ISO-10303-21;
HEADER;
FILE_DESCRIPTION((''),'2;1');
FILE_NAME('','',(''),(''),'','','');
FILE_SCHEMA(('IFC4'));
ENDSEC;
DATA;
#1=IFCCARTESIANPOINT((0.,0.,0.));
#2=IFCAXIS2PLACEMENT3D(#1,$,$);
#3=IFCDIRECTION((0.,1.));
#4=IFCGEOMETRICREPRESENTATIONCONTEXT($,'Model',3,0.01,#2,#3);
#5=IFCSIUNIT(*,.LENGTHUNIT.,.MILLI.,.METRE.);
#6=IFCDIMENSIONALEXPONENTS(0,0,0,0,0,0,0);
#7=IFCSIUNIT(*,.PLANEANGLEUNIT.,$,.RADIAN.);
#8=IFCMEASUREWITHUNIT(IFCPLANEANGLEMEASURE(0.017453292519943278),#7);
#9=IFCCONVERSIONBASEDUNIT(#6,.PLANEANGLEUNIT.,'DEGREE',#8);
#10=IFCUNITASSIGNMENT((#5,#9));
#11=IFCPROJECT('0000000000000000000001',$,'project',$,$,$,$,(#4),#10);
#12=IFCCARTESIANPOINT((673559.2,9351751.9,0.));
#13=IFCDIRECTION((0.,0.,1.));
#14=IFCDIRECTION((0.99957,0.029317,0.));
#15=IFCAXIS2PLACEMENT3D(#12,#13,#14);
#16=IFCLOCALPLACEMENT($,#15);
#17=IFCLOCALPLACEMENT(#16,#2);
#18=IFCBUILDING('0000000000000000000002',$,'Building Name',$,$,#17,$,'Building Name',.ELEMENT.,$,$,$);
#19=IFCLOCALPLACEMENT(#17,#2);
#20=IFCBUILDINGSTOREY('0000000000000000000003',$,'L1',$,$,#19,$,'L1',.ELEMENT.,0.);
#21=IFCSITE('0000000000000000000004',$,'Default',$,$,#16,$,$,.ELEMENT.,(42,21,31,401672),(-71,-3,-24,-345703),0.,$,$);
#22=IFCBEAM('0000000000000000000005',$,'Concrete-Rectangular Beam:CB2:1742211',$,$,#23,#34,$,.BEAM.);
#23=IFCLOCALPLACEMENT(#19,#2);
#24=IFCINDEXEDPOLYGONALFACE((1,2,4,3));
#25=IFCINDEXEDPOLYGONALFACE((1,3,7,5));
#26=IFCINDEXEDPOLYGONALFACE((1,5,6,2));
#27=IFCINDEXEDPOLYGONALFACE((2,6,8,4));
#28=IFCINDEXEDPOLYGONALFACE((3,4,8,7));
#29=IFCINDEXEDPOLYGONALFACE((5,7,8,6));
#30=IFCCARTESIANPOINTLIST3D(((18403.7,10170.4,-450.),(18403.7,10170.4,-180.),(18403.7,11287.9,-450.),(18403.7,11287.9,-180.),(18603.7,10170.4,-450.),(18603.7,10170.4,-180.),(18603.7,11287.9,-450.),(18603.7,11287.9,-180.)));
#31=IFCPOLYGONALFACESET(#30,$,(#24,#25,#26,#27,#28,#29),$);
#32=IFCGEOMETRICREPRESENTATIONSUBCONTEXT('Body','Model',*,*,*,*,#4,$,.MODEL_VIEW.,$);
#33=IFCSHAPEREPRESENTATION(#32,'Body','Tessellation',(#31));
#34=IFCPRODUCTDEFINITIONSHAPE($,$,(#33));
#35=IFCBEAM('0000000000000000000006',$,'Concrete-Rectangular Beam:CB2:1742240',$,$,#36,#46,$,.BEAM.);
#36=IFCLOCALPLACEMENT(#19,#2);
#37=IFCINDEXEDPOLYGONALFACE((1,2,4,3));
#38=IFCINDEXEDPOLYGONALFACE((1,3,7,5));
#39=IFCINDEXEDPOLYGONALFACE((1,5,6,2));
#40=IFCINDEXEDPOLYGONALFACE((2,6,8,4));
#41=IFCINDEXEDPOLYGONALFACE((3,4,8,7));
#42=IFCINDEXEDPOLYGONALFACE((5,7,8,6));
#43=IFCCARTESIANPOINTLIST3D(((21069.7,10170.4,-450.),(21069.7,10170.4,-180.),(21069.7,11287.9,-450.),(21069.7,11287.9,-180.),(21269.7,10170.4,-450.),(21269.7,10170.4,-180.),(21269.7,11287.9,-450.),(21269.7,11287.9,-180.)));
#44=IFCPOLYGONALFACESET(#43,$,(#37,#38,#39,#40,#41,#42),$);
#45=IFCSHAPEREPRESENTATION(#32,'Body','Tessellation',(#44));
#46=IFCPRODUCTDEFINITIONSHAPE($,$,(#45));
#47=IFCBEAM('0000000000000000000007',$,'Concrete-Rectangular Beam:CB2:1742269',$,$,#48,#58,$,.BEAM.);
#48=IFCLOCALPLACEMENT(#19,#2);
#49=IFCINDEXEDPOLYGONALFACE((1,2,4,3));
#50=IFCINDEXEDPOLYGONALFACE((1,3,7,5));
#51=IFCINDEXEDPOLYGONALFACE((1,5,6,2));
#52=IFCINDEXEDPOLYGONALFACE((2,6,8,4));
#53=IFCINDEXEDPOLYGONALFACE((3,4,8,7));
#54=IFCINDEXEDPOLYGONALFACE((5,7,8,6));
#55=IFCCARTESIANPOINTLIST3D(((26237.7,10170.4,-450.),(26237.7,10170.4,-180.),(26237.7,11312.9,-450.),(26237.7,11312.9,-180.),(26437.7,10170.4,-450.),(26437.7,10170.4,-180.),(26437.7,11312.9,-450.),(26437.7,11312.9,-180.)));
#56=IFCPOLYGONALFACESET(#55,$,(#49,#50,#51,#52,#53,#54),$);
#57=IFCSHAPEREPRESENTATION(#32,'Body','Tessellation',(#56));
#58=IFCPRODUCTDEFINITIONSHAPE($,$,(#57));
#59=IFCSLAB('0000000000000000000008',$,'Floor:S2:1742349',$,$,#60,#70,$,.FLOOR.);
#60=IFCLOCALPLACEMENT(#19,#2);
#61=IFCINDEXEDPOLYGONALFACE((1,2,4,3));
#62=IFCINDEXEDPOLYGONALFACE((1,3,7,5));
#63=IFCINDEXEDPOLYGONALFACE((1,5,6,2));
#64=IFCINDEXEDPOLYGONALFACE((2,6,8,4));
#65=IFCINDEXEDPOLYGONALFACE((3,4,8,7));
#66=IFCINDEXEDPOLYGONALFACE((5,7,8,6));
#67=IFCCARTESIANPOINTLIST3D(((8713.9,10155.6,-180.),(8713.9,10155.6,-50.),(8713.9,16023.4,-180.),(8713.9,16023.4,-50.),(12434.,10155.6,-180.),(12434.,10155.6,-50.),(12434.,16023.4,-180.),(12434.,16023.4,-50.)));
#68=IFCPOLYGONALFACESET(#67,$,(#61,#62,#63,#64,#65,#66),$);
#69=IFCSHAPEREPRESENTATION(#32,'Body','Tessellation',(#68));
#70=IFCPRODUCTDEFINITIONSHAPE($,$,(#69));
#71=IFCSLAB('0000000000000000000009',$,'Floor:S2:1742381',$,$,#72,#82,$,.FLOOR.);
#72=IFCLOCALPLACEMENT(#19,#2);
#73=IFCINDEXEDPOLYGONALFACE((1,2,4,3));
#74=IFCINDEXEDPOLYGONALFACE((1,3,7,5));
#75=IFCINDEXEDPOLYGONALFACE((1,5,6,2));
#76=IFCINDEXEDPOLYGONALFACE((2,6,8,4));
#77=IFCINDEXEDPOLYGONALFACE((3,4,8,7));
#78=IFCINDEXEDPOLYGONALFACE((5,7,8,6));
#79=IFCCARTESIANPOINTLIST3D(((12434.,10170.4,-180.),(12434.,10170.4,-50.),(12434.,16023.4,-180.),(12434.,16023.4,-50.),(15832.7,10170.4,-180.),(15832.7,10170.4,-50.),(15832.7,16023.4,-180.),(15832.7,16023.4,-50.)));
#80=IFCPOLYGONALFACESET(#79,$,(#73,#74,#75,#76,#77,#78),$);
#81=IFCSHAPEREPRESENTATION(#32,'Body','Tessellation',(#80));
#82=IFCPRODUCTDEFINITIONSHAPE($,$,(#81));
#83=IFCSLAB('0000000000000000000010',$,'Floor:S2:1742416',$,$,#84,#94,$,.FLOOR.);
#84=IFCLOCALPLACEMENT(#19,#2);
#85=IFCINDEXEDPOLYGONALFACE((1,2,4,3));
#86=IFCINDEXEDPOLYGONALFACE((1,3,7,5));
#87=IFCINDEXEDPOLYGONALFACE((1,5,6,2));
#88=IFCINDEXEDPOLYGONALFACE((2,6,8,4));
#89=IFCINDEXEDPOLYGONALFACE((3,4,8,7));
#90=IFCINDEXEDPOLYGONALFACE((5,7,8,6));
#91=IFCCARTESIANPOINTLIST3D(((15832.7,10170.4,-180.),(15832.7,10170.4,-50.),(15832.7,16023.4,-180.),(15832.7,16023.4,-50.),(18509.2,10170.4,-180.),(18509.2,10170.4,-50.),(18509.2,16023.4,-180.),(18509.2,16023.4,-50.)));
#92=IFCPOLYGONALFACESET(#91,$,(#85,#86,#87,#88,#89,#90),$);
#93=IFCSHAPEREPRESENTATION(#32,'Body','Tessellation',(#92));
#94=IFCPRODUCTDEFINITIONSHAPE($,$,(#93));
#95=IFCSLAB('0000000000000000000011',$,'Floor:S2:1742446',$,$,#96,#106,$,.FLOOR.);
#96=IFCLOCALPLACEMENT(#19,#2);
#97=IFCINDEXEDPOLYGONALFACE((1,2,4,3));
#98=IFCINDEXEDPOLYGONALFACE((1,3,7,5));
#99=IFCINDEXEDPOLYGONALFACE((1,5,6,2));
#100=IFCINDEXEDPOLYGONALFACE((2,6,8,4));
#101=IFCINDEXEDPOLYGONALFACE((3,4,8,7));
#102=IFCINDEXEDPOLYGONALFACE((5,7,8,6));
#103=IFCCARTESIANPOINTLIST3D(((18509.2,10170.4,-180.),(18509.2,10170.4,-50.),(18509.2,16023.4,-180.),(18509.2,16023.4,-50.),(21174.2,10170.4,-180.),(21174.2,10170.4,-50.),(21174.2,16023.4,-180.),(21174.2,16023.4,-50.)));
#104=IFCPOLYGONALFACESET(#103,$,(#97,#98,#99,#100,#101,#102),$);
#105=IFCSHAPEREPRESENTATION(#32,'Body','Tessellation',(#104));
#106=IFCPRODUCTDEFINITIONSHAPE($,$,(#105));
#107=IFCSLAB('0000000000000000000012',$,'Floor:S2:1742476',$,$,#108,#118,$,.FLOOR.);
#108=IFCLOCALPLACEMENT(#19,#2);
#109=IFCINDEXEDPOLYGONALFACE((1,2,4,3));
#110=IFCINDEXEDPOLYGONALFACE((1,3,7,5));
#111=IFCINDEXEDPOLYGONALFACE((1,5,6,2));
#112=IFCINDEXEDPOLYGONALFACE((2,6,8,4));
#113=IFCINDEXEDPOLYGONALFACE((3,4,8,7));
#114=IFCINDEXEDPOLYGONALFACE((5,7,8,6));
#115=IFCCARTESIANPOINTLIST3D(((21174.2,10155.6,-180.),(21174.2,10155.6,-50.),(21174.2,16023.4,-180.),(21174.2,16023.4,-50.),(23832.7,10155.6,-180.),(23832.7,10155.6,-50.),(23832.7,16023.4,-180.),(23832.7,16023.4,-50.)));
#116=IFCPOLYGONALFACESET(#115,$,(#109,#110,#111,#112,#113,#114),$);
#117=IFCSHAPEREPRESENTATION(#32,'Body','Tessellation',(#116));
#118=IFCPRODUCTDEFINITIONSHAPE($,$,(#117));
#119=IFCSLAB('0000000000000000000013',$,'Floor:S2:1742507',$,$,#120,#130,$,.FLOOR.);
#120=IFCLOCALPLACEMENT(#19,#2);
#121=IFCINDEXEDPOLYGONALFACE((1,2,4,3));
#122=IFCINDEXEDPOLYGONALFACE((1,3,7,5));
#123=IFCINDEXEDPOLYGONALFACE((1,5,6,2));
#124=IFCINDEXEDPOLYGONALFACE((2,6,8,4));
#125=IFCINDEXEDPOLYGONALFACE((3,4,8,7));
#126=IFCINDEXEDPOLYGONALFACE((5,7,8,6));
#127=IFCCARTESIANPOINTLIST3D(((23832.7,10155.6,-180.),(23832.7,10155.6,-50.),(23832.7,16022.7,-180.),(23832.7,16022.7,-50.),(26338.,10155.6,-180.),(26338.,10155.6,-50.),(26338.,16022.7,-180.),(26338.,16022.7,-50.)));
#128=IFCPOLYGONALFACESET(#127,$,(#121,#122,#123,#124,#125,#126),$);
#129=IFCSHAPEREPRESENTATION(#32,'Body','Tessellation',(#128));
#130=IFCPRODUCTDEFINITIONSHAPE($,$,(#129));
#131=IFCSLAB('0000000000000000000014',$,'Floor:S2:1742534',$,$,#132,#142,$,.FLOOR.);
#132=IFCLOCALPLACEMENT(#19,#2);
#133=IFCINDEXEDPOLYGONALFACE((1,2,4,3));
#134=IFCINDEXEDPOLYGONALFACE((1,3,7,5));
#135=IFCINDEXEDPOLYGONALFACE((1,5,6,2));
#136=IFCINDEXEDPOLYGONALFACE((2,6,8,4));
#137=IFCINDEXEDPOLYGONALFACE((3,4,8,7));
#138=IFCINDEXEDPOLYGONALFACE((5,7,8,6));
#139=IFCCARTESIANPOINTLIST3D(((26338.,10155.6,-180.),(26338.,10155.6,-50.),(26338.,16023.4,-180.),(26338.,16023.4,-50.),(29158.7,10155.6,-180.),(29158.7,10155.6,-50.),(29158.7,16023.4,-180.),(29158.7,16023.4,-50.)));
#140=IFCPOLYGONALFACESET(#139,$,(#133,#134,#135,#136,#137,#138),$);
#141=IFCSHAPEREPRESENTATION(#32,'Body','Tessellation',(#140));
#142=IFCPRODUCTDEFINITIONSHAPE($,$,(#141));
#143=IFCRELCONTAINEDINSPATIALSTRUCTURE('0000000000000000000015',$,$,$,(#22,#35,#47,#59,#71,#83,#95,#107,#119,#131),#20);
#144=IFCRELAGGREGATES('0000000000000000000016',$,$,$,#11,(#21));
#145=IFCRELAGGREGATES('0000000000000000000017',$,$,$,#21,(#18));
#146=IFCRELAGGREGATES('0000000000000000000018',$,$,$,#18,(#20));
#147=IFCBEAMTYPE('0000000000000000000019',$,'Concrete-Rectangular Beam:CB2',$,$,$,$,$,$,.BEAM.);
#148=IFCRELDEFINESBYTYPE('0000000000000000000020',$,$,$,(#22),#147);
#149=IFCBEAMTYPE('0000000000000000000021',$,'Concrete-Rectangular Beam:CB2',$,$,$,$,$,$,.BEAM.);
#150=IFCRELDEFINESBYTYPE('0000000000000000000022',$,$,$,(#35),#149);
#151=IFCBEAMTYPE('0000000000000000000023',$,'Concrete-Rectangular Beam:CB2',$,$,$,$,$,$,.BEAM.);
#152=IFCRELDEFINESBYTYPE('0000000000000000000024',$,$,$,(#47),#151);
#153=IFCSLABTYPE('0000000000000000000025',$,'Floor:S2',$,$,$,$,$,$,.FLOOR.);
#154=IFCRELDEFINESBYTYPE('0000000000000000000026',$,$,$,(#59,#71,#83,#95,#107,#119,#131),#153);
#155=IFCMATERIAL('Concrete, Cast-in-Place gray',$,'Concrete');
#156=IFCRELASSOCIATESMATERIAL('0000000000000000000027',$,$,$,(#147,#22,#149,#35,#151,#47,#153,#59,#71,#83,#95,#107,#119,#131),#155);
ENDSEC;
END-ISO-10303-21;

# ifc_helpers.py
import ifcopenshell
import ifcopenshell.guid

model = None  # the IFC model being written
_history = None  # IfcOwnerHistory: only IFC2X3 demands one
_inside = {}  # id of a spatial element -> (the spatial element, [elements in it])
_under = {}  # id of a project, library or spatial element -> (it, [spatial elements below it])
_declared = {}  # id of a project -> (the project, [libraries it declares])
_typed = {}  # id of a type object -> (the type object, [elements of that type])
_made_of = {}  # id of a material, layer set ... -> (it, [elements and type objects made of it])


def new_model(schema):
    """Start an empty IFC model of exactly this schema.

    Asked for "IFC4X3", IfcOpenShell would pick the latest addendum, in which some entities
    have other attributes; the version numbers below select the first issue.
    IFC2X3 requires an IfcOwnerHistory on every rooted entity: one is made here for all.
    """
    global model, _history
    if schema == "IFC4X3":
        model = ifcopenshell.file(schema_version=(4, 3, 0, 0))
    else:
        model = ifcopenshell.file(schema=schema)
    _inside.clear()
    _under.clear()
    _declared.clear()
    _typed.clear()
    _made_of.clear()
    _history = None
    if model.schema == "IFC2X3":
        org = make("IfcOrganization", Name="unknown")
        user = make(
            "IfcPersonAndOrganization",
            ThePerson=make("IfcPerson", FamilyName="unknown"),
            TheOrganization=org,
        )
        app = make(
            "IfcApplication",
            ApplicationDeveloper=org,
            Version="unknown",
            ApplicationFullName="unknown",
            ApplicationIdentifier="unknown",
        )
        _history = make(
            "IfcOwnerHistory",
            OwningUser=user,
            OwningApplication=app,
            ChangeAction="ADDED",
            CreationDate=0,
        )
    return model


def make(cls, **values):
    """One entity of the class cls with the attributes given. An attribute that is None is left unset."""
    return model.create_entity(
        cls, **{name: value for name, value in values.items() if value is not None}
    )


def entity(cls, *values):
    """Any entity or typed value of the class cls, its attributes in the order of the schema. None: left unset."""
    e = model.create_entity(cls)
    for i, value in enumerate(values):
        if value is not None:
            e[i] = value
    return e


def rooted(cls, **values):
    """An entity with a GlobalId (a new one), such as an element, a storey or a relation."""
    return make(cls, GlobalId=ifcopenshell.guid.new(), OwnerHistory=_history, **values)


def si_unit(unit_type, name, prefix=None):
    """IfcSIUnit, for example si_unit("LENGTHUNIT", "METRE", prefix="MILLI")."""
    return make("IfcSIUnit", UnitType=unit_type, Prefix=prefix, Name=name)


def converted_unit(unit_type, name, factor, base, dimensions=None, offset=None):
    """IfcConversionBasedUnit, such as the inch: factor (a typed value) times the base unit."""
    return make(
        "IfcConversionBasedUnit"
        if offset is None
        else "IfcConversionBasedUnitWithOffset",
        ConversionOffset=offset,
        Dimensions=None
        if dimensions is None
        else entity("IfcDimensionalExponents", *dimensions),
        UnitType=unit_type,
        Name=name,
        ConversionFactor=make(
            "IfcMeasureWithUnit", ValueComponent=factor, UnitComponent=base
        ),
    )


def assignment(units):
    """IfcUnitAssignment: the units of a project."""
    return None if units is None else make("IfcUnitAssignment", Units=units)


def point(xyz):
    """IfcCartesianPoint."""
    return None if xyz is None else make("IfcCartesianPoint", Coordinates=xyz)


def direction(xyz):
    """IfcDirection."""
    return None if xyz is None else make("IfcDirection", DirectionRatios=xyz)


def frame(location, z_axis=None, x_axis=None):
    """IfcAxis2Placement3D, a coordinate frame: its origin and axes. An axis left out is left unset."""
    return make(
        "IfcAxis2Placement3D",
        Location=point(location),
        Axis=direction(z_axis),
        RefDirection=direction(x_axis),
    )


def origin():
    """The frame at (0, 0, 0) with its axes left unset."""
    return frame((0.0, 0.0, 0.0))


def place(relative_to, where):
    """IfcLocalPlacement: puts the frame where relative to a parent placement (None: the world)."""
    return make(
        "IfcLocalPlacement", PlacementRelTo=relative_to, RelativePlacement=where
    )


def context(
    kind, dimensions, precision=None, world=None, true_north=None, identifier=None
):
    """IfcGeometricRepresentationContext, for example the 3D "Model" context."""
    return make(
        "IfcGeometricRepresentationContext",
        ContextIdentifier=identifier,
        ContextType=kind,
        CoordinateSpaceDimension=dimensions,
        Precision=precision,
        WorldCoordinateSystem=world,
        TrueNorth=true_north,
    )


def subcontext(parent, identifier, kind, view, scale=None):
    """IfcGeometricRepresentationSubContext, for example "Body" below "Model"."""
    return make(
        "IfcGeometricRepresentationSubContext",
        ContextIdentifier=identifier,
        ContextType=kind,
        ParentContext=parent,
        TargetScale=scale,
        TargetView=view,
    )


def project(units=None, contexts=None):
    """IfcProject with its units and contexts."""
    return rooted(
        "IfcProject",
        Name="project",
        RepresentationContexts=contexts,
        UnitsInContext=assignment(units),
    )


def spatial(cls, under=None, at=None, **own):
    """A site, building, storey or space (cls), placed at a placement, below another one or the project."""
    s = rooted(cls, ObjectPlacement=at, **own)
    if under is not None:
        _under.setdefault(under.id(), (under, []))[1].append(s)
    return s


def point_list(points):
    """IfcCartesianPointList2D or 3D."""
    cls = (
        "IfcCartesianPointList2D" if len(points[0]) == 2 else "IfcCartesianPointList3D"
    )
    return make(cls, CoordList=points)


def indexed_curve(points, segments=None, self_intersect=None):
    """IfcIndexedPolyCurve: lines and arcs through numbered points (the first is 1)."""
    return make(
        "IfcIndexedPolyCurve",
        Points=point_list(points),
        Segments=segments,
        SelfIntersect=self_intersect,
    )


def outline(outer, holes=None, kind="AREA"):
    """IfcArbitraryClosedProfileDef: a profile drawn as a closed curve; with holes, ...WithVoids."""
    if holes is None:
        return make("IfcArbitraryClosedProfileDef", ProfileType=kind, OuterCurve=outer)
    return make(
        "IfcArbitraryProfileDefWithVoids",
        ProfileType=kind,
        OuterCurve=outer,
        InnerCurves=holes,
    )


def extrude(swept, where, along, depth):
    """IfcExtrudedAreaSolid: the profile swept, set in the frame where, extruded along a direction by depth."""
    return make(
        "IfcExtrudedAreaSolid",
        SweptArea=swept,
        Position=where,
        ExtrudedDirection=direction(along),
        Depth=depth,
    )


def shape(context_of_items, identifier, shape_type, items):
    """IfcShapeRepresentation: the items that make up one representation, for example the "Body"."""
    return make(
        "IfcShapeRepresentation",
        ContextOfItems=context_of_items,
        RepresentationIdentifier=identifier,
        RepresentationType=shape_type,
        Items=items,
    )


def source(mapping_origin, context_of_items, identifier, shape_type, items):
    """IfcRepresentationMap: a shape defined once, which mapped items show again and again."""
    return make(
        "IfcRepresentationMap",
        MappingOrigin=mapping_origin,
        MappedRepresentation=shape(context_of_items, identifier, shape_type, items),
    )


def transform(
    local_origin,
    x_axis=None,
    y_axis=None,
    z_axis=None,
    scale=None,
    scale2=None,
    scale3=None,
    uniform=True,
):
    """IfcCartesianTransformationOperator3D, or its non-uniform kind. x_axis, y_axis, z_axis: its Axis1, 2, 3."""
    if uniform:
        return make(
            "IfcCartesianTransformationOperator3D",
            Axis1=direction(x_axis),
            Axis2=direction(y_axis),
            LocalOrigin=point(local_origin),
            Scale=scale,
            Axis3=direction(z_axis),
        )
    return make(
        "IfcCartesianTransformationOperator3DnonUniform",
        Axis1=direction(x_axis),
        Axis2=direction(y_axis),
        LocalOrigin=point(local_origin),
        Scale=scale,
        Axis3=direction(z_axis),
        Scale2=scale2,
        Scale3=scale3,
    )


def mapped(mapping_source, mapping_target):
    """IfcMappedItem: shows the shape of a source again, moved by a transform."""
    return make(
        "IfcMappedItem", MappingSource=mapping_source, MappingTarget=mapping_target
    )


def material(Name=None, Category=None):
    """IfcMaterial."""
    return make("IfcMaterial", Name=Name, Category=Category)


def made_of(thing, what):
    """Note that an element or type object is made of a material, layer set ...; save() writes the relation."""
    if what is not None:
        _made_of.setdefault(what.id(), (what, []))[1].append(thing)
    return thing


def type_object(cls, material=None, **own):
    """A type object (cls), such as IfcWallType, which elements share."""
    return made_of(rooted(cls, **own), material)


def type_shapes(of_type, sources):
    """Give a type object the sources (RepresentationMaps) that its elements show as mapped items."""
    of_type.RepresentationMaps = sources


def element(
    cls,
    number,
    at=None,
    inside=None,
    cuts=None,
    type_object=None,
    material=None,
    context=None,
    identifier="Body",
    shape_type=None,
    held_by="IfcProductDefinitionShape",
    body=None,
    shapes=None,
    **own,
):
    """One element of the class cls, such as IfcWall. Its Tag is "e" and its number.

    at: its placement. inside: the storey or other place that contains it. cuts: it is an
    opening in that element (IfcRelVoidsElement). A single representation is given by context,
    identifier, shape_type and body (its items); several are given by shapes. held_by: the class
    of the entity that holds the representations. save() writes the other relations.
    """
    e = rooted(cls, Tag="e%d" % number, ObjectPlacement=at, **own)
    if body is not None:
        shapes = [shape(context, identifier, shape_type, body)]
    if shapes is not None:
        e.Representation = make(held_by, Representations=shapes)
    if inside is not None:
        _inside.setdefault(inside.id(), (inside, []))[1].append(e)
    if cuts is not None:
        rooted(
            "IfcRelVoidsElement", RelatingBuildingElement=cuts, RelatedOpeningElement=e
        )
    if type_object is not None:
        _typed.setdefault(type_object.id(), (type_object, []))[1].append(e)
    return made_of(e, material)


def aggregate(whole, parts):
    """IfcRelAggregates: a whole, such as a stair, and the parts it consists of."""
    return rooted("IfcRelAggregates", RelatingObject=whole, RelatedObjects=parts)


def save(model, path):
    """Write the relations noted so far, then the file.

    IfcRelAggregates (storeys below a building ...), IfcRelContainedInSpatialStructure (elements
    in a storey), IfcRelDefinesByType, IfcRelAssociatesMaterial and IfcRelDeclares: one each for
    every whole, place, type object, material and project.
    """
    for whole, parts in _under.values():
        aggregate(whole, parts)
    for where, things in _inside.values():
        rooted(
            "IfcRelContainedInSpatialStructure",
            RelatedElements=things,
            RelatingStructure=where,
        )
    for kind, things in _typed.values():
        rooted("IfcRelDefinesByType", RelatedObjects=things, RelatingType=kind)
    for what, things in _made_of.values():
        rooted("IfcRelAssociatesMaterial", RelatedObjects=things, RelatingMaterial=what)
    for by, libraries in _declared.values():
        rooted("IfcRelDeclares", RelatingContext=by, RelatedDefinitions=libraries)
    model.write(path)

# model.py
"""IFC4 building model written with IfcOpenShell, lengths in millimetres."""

from ifc_helpers import new_model, entity, si_unit, converted_unit, direction, frame, origin, place, context, subcontext, project, spatial, indexed_curve, outline, extrude, source, transform, mapped, material, type_object, type_shapes, element, save


model = new_model("IFC4")

# Units and contexts
model_context = context("Model", 3, precision=0.01, world=origin(), true_north=direction((0.0, 1.0)))
body_context = subcontext(model_context, "Body", "Model", "MODEL_VIEW")
ifc_project = project(units=[si_unit("LENGTHUNIT", "METRE", prefix="MILLI"), converted_unit("PLANEANGLEUNIT", "DEGREE", entity("IfcPlaneAngleMeasure", 0.017453292519943278), si_unit("PLANEANGLEUNIT", "RADIAN"), dimensions=[0, 0, 0, 0, 0, 0, 0])], contexts=[model_context])

# Site, building, storey
site_placement = place(None, frame((673559.2, 9351751.9, 0.0), z_axis=(0.0, 0.0, 1.0), x_axis=(0.99957, 0.029317, 0.0)))
site = spatial("IfcSite", under=ifc_project, at=site_placement, Name="Default", CompositionType="ELEMENT", RefLatitude=(42, 21, 31, 401672), RefLongitude=(-71, -3, -24, -345703), RefElevation=0.0)
building_placement = place(site_placement, origin())
building = spatial("IfcBuilding", under=site, at=building_placement, Name="Building Name", LongName="Building Name", CompositionType="ELEMENT")
storey_placement = place(building_placement, origin())
storey = spatial("IfcBuildingStorey", under=building, at=storey_placement, Name="L1", LongName="L1", CompositionType="ELEMENT", Elevation=0.0)

# Beams
ifc_material = material(Name="Concrete, Cast-in-Place gray", Category="Concrete")
beam_type_1 = type_object("IfcBeamType", Name="Concrete-Rectangular Beam:CB2", PredefinedType="BEAM", material=ifc_material)
shared_shape_1 = source(origin(), body_context, "Body", "SweptSolid", [
    extrude(outline(indexed_curve([(-100.0, -135.0), (100.0, -135.0), (100.0, 135.0), (-100.0, 135.0), (-100.0, -135.0)], self_intersect=False)), frame((18503.7, 11287.9, -315.0), z_axis=(0.0, -1.0, 0.0), x_axis=(-1.0, 0.0, 0.0)), (0.0, 0.0, 1.0), 1117.5),
])
type_shapes(beam_type_1, [shared_shape_1])
beam_1_placement = place(storey_placement, origin())
element("IfcBeam", 1, at=beam_1_placement, inside=storey, type_object=beam_type_1, material=ifc_material, Name="Concrete-Rectangular Beam:CB2:1742211", PredefinedType="BEAM", context=body_context, shape_type="MappedRepresentation", body=[
    mapped(shared_shape_1, transform((0.0, 0.0, 0.0), scale=1.0)),
])
beam_type_2 = type_object("IfcBeamType", Name="Concrete-Rectangular Beam:CB2", PredefinedType="BEAM", material=ifc_material)
shared_shape_2 = source(origin(), body_context, "Body", "SweptSolid", [
    extrude(outline(indexed_curve([(-100.0, -135.0), (100.0, -135.0), (100.0, 135.0), (-100.0, 135.0), (-100.0, -135.0)], self_intersect=False)), frame((21169.7, 11287.9, -315.0), z_axis=(0.0, -1.0, 0.0), x_axis=(-1.0, 0.0, 0.0)), (0.0, 0.0, 1.0), 1117.5),
])
type_shapes(beam_type_2, [shared_shape_2])
beam_2_placement = place(storey_placement, origin())
element("IfcBeam", 2, at=beam_2_placement, inside=storey, type_object=beam_type_2, material=ifc_material, Name="Concrete-Rectangular Beam:CB2:1742240", PredefinedType="BEAM", context=body_context, shape_type="MappedRepresentation", body=[
    mapped(shared_shape_2, transform((0.0, 0.0, 0.0), scale=1.0)),
])
beam_type_3 = type_object("IfcBeamType", Name="Concrete-Rectangular Beam:CB2", PredefinedType="BEAM", material=ifc_material)
shared_shape_3 = source(origin(), body_context, "Body", "SweptSolid", [
    extrude(outline(indexed_curve([(-100.0, -135.0), (100.0, -135.0), (100.0, 135.0), (-100.0, 135.0), (-100.0, -135.0)], self_intersect=False)), frame((26337.7, 11312.9, -315.0), z_axis=(0.0, -1.0, 0.0), x_axis=(-1.0, 0.0, 0.0)), (0.0, 0.0, 1.0), 1142.5),
])
type_shapes(beam_type_3, [shared_shape_3])
beam_3_placement = place(storey_placement, origin())
element("IfcBeam", 3, at=beam_3_placement, inside=storey, type_object=beam_type_3, material=ifc_material, Name="Concrete-Rectangular Beam:CB2:1742269", PredefinedType="BEAM", context=body_context, shape_type="MappedRepresentation", body=[
    mapped(shared_shape_3, transform((0.0, 0.0, 0.0), scale=1.0)),
])

# Slabs
slab_type = type_object("IfcSlabType", Name="Floor:S2", PredefinedType="FLOOR", material=ifc_material)
slab_1_placement = place(storey_placement, origin())
element("IfcSlab", 4, at=slab_1_placement, inside=storey, type_object=slab_type, material=ifc_material, Name="Floor:S2:1742349", PredefinedType="FLOOR", context=body_context, shape_type="SweptSolid", body=[
    extrude(outline(indexed_curve([(-2933.9, -1860.1), (2933.9, -1860.1), (2933.9, 1860.1), (-2933.9, 1860.1), (-2933.9, -1860.1)], self_intersect=False)), frame((10574.0, 13089.5, -50.0), z_axis=(0.0, 0.0, -1.0), x_axis=(0.0, 1.0, 0.0)), (0.0, 0.0, 1.0), 130.0),
])
slab_2_placement = place(storey_placement, origin())
element("IfcSlab", 5, at=slab_2_placement, inside=storey, type_object=slab_type, material=ifc_material, Name="Floor:S2:1742381", PredefinedType="FLOOR", context=body_context, shape_type="SweptSolid", body=[
    extrude(outline(indexed_curve([(-2926.5, -1699.3), (2926.5, -1699.3), (2926.5, 1699.3), (-2926.5, 1699.3), (-2926.5, -1699.3)], self_intersect=False)), frame((14133.4, 13096.9, -50.0), z_axis=(0.0, 0.0, -1.0), x_axis=(0.0, 1.0, 0.0)), (0.0, 0.0, 1.0), 130.0),
])
slab_3_placement = place(storey_placement, origin())
element("IfcSlab", 6, at=slab_3_placement, inside=storey, type_object=slab_type, material=ifc_material, Name="Floor:S2:1742416", PredefinedType="FLOOR", context=body_context, shape_type="SweptSolid", body=[
    extrude(outline(indexed_curve([(-2926.5, -1338.3), (2926.5, -1338.3), (2926.5, 1338.3), (-2926.5, 1338.3), (-2926.5, -1338.3)], self_intersect=False)), frame((17170.9, 13096.9, -50.0), z_axis=(0.0, 0.0, -1.0), x_axis=(0.0, 1.0, 0.0)), (0.0, 0.0, 1.0), 130.0),
])
slab_4_placement = place(storey_placement, origin())
element("IfcSlab", 7, at=slab_4_placement, inside=storey, type_object=slab_type, material=ifc_material, Name="Floor:S2:1742446", PredefinedType="FLOOR", context=body_context, shape_type="SweptSolid", body=[
    extrude(outline(indexed_curve([(-2926.5, -1332.5), (2926.5, -1332.5), (2926.5, 1332.5), (-2926.5, 1332.5), (-2926.5, -1332.5)], self_intersect=False)), frame((19841.7, 13096.9, -50.0), z_axis=(0.0, 0.0, -1.0), x_axis=(0.0, 1.0, 0.0)), (0.0, 0.0, 1.0), 130.0),
])
slab_5_placement = place(storey_placement, origin())
element("IfcSlab", 8, at=slab_5_placement, inside=storey, type_object=slab_type, material=ifc_material, Name="Floor:S2:1742476", PredefinedType="FLOOR", context=body_context, shape_type="SweptSolid", body=[
    extrude(outline(indexed_curve([(-2933.9, -1329.2), (2933.9, -1329.2), (2933.9, 1329.2), (-2933.9, 1329.2), (-2933.9, -1329.2)], self_intersect=False)), frame((22503.4, 13089.5, -50.0), z_axis=(0.0, 0.0, -1.0), x_axis=(0.0, 1.0, 0.0)), (0.0, 0.0, 1.0), 130.0),
])
slab_6_placement = place(storey_placement, origin())
element("IfcSlab", 9, at=slab_6_placement, inside=storey, type_object=slab_type, material=ifc_material, Name="Floor:S2:1742507", PredefinedType="FLOOR", context=body_context, shape_type="SweptSolid", body=[
    extrude(outline(indexed_curve([(-2933.6, -1252.7), (2933.6, -1252.7), (2933.6, 1252.7), (-2933.6, 1252.7), (-2933.6, -1252.7)], self_intersect=False)), frame((25085.3, 13089.2, -50.0), z_axis=(0.0, 0.0, -1.0), x_axis=(0.0, 1.0, 0.0)), (0.0, 0.0, 1.0), 130.0),
])
slab_7_placement = place(storey_placement, origin())
element("IfcSlab", 10, at=slab_7_placement, inside=storey, type_object=slab_type, material=ifc_material, Name="Floor:S2:1742534", PredefinedType="FLOOR", context=body_context, shape_type="SweptSolid", body=[
    extrude(outline(indexed_curve([(-2933.9, -1410.4), (2933.9, -1410.4), (2933.9, 1410.4), (-2933.9, 1410.4), (-2933.9, -1410.4)], self_intersect=False)), frame((27748.3, 13089.5, -50.0), z_axis=(0.0, 0.0, -1.0), x_axis=(0.0, 1.0, 0.0)), (0.0, 0.0, 1.0), 130.0),
])

save(model, "model.ifc")
